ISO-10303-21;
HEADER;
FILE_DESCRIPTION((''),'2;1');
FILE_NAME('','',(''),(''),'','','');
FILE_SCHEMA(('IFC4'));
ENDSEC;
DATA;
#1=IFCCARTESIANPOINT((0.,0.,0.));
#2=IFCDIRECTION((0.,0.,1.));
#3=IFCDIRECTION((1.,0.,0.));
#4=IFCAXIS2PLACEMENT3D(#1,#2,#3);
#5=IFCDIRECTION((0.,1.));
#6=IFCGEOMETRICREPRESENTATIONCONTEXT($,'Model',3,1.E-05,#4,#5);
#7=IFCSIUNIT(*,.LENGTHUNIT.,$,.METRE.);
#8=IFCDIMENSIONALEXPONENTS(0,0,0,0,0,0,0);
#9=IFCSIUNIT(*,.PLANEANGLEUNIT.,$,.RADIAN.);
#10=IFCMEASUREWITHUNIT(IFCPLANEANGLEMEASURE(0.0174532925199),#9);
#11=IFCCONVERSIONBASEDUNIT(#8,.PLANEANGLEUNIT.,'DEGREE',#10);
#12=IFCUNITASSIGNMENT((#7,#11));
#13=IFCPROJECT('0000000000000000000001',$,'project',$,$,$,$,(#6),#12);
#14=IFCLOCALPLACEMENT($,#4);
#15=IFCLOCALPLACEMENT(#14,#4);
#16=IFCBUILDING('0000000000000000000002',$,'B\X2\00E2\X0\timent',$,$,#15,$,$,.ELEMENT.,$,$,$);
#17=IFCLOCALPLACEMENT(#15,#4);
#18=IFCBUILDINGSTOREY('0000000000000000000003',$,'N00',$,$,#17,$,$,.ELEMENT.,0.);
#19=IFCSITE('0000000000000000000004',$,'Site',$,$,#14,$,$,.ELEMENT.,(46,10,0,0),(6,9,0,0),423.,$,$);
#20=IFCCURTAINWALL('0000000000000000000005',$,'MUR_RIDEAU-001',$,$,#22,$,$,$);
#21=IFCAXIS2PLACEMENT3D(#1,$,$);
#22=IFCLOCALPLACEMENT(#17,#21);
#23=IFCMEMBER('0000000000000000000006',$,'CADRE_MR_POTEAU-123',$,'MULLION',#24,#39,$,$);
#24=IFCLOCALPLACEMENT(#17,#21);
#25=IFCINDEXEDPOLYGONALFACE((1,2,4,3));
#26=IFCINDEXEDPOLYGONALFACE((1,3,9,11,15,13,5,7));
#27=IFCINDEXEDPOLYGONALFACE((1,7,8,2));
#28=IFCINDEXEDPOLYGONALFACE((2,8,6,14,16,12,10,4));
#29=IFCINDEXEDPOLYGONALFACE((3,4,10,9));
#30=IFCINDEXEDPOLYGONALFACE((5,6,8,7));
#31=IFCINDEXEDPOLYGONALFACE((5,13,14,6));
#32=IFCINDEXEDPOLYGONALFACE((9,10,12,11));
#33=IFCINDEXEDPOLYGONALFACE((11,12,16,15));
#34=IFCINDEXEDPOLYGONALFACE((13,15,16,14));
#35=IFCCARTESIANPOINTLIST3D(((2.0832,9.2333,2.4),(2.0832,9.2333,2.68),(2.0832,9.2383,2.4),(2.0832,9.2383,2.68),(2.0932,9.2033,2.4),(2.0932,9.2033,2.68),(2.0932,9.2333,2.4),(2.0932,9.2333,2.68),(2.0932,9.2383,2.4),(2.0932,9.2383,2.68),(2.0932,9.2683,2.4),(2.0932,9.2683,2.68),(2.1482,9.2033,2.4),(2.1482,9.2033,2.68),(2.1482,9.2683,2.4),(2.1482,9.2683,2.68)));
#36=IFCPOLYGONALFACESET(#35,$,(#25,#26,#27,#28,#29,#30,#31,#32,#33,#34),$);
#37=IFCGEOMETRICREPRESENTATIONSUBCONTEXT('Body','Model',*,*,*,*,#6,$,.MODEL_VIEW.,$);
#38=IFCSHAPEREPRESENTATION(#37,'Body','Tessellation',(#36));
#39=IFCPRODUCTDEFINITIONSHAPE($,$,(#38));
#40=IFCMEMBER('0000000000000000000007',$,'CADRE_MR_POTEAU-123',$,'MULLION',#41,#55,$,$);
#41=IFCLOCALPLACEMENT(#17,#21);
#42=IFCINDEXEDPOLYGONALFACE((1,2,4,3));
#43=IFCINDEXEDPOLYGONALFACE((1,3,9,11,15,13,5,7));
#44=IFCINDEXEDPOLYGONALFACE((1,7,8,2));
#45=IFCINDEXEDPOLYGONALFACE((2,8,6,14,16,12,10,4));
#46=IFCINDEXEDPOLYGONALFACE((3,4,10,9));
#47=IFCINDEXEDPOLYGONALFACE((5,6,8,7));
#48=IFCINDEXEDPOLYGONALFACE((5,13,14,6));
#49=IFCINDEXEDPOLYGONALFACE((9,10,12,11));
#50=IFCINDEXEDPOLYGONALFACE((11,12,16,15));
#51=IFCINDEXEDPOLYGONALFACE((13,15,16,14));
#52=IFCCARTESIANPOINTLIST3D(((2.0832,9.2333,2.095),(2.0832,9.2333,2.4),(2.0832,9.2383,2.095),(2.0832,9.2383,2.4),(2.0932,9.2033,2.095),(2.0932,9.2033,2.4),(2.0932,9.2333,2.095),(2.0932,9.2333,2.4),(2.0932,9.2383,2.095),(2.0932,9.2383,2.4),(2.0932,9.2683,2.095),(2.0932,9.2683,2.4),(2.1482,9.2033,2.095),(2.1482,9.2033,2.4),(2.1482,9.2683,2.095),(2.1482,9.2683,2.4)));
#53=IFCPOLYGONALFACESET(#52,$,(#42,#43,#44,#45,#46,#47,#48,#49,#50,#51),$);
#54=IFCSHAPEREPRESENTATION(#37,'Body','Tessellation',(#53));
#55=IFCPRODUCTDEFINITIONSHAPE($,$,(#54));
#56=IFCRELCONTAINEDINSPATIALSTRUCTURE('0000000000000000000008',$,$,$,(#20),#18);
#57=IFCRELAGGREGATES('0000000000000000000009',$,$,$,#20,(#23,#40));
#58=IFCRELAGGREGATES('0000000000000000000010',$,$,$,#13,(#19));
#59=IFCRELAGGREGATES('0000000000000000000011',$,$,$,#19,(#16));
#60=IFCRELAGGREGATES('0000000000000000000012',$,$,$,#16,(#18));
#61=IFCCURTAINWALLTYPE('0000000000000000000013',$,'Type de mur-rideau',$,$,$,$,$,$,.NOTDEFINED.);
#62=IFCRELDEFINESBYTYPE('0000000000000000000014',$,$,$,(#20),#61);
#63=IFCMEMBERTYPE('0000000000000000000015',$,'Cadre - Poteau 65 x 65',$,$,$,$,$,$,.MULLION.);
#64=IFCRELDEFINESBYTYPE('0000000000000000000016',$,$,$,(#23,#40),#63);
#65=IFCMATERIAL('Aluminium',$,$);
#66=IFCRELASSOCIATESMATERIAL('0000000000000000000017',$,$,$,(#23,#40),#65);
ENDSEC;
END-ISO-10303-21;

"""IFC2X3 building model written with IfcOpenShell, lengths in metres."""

from ifc_helpers import new_model, entity, si_unit, converted_unit, direction, frame, origin_with_axes, place, context, subcontext, project, spatial, polyline, outline, extrude, material, type_object, element, aggregate, save


model = new_model("IFC2X3")

# Units and contexts
model_context = context("Model", 3, precision=1e-05, world=origin_with_axes(), true_north=direction((0.0, 1.0)))
body_context = subcontext(model_context, "Body", "Model", "MODEL_VIEW")
ifc_project = project(units=[si_unit("LENGTHUNIT", "METRE"), converted_unit("PLANEANGLEUNIT", "DEGREE", entity("IfcPlaneAngleMeasure", 0.0174532925199), si_unit("PLANEANGLEUNIT", "RADIAN"), dimensions=[0, 0, 0, 0, 0, 0, 0])], contexts=[model_context])

# Site, building, storey
site_placement = place(None, origin_with_axes())
site = spatial("IfcSite", under=ifc_project, at=site_placement, Name="Site", CompositionType="ELEMENT", RefLatitude=(46, 10, 0, 0), RefLongitude=(6, 9, 0, 0), RefElevation=423.0)
building_placement = place(site_placement, origin_with_axes())
building = spatial("IfcBuilding", under=site, at=building_placement, Name="Bâtiment", CompositionType="ELEMENT")
storey_placement = place(building_placement, origin_with_axes())
storey = spatial("IfcBuildingStorey", under=building, at=storey_placement, Name="N00", CompositionType="ELEMENT", Elevation=0.0)

# Curtain wall, members
curtain_wall_type = type_object("IfcCurtainWallType", Name="Type de mur-rideau", PredefinedType="NOTDEFINED")
curtain_wall_placement = place(storey_placement, frame((2.0832, 6.4208, 0.0), z_axis=(0.0, 0.0, 1.0), x_axis=(1.0, 0.0, 0.0)))
curtain_wall = element("IfcCurtainWall", 1, at=curtain_wall_placement, inside=storey, type_object=curtain_wall_type, Name="MUR_RIDEAU-001")
ifc_material = material(Name="Aluminium")
member_type_1 = type_object("IfcMemberType", Name="Cadre - Poteau 65 x 65", PredefinedType="MULLION")
member_1_placement = place(curtain_wall_placement, frame((0.0, 2.8149, 2.4), z_axis=(0.0, 0.0, 1.0), x_axis=(0.0, 1.0, 0.0)))
member_1 = element("IfcMember", 2, at=member_1_placement, type_object=member_type_1, material=ifc_material, Name="CADRE_MR_POTEAU-123", ObjectType="MULLION", context=body_context, shape_type="SweptSolid", body=[
    extrude(outline(polyline([(0.01, -0.0025), (0.01, -0.0325), (0.065, -0.0325), (0.065, 0.0325), (0.01, 0.0325), (0.01, 0.0025), (0.0, 0.0025), (0.0, -0.0025), (0.01, -0.0025)])), frame((0.0, 0.0, 0.0), z_axis=(0.0, 0.0, 1.0), x_axis=(0.0, -1.0, 0.0)), (0.0, 0.0, 1.0), 0.28),
])
member_2_placement = place(curtain_wall_placement, frame((0.0, 2.8149, 2.095), z_axis=(0.0, 0.0, 1.0), x_axis=(0.0, 1.0, 0.0)))
member_2 = element("IfcMember", 3, at=member_2_placement, type_object=member_type_1, material=ifc_material, Name="CADRE_MR_POTEAU-123", ObjectType="MULLION", context=body_context, shape_type="SweptSolid", body=[
    extrude(outline(polyline([(0.01, -0.0025), (0.01, -0.0325), (0.065, -0.0325), (0.065, 0.0325), (0.01, 0.0325), (0.01, 0.0025), (0.0, 0.0025), (0.0, -0.0025), (0.01, -0.0025)])), frame((0.0, 0.0, 0.0), z_axis=(0.0, 0.0, 1.0), x_axis=(0.0, -1.0, 0.0)), (0.0, 0.0, 1.0), 0.305),
])
aggregate(curtain_wall, [member_1, member_2])

save(model, "model.ifc")
